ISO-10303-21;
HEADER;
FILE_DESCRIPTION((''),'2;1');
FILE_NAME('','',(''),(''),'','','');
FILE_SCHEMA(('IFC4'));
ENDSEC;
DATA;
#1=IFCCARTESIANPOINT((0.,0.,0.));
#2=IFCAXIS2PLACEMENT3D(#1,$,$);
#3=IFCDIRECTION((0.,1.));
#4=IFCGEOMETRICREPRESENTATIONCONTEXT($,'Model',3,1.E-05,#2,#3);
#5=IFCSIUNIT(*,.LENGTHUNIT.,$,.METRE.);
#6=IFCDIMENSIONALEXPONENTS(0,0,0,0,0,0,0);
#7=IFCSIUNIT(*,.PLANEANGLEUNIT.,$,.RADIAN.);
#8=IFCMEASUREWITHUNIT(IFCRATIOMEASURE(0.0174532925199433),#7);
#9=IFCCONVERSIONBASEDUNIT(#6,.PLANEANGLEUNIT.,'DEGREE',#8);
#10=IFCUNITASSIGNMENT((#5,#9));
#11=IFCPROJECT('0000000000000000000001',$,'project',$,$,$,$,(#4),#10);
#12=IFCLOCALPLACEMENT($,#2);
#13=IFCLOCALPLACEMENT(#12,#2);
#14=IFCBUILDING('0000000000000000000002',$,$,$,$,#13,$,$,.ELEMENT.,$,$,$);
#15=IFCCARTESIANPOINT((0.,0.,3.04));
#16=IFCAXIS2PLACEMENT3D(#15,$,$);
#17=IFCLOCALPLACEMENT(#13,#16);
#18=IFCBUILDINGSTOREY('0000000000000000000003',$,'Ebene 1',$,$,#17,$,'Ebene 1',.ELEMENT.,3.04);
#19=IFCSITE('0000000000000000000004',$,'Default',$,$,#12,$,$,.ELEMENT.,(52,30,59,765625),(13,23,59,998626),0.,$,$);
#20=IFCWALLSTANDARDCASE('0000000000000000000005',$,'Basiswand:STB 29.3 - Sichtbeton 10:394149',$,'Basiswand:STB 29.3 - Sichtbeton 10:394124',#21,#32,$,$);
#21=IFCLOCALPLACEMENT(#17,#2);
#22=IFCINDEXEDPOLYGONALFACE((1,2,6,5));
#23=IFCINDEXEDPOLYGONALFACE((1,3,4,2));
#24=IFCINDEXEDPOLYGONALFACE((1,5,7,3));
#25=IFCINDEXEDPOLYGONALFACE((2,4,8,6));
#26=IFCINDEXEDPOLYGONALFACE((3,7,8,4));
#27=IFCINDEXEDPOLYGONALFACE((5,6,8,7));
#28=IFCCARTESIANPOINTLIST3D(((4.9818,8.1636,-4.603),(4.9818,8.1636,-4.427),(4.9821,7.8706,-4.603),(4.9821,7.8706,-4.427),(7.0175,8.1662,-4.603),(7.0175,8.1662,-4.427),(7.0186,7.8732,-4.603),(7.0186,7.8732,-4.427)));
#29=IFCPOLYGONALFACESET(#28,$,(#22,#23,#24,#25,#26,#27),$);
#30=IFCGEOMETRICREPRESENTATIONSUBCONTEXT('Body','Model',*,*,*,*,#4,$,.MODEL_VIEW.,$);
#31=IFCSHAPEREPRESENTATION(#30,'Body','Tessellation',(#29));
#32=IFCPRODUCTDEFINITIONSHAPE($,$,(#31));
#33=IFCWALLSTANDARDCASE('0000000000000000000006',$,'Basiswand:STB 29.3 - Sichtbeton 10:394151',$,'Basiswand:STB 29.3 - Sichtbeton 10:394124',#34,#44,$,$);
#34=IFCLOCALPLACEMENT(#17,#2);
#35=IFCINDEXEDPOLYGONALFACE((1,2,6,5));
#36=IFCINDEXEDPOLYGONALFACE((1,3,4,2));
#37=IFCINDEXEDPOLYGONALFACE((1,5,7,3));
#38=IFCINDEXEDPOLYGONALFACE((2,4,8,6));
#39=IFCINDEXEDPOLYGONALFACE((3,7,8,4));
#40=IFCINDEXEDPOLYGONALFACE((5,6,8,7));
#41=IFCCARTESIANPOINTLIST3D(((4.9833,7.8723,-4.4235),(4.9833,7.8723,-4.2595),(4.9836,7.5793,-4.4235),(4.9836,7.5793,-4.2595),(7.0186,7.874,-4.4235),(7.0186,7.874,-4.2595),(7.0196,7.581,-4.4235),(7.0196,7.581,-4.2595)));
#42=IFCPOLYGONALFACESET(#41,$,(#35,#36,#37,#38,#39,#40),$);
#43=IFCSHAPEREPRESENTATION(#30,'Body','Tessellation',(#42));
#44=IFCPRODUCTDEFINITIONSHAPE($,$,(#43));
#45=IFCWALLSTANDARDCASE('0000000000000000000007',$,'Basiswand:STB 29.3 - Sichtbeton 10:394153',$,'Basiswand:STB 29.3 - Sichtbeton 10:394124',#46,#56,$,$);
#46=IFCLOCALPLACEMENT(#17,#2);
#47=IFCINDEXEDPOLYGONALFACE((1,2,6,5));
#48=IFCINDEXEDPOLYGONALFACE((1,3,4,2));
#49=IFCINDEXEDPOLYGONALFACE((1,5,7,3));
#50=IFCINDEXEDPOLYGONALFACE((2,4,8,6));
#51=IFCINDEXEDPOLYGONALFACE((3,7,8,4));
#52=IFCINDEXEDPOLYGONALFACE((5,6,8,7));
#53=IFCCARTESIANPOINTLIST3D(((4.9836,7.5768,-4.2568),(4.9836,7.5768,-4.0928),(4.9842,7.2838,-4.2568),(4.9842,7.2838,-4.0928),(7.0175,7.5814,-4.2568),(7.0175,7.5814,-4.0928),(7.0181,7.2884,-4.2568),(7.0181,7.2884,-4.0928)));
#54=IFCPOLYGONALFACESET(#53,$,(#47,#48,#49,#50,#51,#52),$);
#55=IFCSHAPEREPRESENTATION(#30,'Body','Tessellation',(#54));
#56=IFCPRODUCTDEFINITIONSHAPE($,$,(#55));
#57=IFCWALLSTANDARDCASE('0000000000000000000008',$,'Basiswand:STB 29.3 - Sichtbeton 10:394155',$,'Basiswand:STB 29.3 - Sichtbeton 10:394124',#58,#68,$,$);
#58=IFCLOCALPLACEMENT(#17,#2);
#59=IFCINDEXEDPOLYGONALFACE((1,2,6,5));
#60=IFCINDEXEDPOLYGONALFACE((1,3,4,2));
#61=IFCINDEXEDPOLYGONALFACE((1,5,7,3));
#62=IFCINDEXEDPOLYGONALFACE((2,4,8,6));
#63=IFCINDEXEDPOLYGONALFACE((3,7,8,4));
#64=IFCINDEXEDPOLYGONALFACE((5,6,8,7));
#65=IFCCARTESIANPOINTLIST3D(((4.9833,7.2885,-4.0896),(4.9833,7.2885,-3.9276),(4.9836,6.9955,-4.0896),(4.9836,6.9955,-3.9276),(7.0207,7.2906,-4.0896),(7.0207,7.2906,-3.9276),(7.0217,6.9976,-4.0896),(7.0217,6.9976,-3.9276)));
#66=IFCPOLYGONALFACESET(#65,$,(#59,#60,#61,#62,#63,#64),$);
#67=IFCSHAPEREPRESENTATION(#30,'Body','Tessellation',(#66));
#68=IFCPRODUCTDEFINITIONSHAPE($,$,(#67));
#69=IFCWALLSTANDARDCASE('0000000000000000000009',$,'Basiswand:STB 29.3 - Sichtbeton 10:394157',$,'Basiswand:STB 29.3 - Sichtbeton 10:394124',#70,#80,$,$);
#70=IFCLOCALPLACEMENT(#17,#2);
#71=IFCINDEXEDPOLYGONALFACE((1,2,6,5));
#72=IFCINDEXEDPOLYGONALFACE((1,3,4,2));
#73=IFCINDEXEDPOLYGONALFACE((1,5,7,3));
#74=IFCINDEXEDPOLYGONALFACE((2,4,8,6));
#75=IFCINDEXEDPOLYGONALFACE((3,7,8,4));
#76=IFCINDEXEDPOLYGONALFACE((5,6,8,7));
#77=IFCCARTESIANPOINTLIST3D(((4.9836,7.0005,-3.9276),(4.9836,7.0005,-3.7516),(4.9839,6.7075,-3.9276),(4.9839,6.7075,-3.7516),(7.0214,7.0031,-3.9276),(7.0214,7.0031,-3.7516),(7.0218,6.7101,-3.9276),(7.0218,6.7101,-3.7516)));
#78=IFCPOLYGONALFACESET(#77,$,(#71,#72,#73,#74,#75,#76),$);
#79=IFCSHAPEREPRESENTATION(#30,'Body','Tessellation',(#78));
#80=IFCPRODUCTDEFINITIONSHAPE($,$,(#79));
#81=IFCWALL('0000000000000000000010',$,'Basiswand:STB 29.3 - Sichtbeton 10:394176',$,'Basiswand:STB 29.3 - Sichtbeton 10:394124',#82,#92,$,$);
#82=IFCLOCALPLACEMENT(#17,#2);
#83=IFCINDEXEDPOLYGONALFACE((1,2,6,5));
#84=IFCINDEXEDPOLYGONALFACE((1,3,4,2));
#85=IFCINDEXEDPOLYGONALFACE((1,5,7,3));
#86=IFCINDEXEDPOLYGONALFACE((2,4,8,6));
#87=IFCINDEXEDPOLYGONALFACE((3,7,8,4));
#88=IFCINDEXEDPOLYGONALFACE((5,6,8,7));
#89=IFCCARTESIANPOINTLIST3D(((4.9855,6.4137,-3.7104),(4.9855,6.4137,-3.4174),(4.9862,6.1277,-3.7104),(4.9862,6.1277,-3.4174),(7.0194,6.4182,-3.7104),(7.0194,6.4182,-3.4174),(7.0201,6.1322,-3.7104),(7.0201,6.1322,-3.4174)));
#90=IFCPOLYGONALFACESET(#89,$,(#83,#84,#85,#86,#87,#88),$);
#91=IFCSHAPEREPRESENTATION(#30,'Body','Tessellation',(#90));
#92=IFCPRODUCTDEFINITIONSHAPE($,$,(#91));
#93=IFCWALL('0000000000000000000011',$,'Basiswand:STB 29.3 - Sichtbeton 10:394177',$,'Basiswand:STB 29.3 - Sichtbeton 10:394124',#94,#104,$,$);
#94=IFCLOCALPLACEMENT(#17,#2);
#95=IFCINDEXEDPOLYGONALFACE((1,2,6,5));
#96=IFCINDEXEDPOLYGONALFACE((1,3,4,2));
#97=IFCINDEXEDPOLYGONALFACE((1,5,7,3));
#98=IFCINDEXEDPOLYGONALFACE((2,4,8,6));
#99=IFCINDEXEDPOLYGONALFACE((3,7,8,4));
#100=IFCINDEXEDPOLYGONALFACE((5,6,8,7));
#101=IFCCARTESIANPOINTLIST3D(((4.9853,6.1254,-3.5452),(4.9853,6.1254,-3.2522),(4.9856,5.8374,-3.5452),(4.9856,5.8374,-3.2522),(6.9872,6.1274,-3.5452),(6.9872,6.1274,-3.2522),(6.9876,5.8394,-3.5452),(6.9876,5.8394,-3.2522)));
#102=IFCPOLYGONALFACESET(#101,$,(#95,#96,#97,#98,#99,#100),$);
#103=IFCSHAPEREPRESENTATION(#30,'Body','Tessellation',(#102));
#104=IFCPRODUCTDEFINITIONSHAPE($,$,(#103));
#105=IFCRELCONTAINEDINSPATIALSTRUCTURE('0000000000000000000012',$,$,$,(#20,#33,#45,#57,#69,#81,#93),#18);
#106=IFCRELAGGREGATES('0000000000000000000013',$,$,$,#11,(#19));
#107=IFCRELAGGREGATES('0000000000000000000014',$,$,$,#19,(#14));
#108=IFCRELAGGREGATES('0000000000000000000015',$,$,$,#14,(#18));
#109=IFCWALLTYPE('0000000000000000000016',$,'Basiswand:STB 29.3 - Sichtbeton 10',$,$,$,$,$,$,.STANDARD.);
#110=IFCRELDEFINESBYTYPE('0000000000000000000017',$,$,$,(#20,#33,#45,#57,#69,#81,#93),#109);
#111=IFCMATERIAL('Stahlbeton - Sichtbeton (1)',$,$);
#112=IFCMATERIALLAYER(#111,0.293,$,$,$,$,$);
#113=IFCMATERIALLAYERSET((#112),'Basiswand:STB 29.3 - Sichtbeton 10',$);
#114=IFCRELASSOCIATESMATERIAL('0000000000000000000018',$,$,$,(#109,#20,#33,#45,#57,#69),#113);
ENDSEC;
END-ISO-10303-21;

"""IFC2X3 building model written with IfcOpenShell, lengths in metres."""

from ifc_helpers import new_model, entity, si_unit, converted_unit, direction, frame, frame_2d, origin, place, context, subcontext, project, spatial, polyline, rectangle, outline, extrude, clip, halfspace, material, layer, layer_set, layer_usage, type_object, element, save


model = new_model("IFC2X3")

# Units and contexts
model_context = context("Model", 3, precision=1e-05, world=origin(), true_north=direction((0.0, 1.0)))
body_context = subcontext(model_context, "Body", "Model", "MODEL_VIEW")
ifc_project = project(units=[si_unit("LENGTHUNIT", "METRE"), converted_unit("PLANEANGLEUNIT", "DEGREE", entity("IfcRatioMeasure", 0.0174532925199433), si_unit("PLANEANGLEUNIT", "RADIAN"), dimensions=[0, 0, 0, 0, 0, 0, 0])], contexts=[model_context])

# Site, building, storey
site_placement = place(None, origin())
site = spatial("IfcSite", under=ifc_project, at=site_placement, Name="Default", CompositionType="ELEMENT", RefLatitude=(52, 30, 59, 765625), RefLongitude=(13, 23, 59, 998626), RefElevation=0.0)
building_placement = place(site_placement, origin())
building = spatial("IfcBuilding", under=site, at=building_placement, CompositionType="ELEMENT")
storey_placement = place(building_placement, frame((0.0, 0.0, 3.04)))
storey = spatial("IfcBuildingStorey", under=building, at=storey_placement, Name="Ebene 1", LongName="Ebene 1", CompositionType="ELEMENT", Elevation=3.04)

# Walls
ifc_material = material(Name="Stahlbeton - Sichtbeton (1)")
ifc_layer = layer(ifc_material, 0.293)
ifc_layer_set = layer_set([ifc_layer], Name="Basiswand:STB 29.3 - Sichtbeton 10")
ifc_layer_usage_1 = layer_usage(ifc_layer_set, "AXIS2", "POSITIVE", -0.1465)
wall_type = type_object("IfcWallType", Name="Basiswand:STB 29.3 - Sichtbeton 10", PredefinedType="STANDARD", material=ifc_layer_set)
wall_1_placement = place(storey_placement, frame((7.0184, 8.0197, -4.603), z_axis=(0.0, 0.0, 1.0), x_axis=(-0.999999, -0.001264, 0.0)))
element("IfcWallStandardCase", 1, at=wall_1_placement, inside=storey, type_object=wall_type, material=ifc_layer_usage_1, Name="Basiswand:STB 29.3 - Sichtbeton 10:394149", ObjectType="Basiswand:STB 29.3 - Sichtbeton 10:394124", context=body_context, shape_type="SweptSolid", body=[
    extrude(outline(polyline([(2.0364, -0.1465), (2.0364, 0.1465), (0.0, 0.1465), (0.0007, -0.1465), (2.0364, -0.1465)])), origin(), (0.0, 0.0, 1.0), 0.176),
])
ifc_layer_usage_2 = layer_usage(ifc_layer_set, "AXIS2", "POSITIVE", -0.1465)
wall_2_placement = place(storey_placement, frame((7.0195, 7.7275, -4.4235), z_axis=(0.0, 0.0, 1.0), x_axis=(-1.0, -0.000827, 0.0)))
element("IfcWallStandardCase", 2, at=wall_2_placement, inside=storey, type_object=wall_type, material=ifc_layer_usage_2, Name="Basiswand:STB 29.3 - Sichtbeton 10:394151", ObjectType="Basiswand:STB 29.3 - Sichtbeton 10:394124", context=body_context, shape_type="SweptSolid", body=[
    extrude(outline(polyline([(2.0361, -0.1465), (2.0361, 0.1465), (0.0, 0.1465), (0.0008, -0.1465), (2.0361, -0.1465)])), origin(), (0.0, 0.0, 1.0), 0.164),
])
ifc_layer_usage_3 = layer_usage(ifc_layer_set, "AXIS2", "POSITIVE", -0.1465)
wall_3_placement = place(storey_placement, frame((7.0178, 7.4349, -4.2568), z_axis=(0.0, 0.0, 1.0), x_axis=(-0.999998, -0.002231, 0.0)))
element("IfcWallStandardCase", 3, at=wall_3_placement, inside=storey, type_object=wall_type, material=ifc_layer_usage_3, Name="Basiswand:STB 29.3 - Sichtbeton 10:394153", ObjectType="Basiswand:STB 29.3 - Sichtbeton 10:394124", context=body_context, shape_type="SweptSolid", body=[
    extrude(rectangle(XDim=2.0339, YDim=0.293, at=frame_2d((1.0169, 0.0), x_axis=(-1.0, 0.0))), origin(), (0.0, 0.0, 1.0), 0.164),
])
ifc_layer_usage_4 = layer_usage(ifc_layer_set, "AXIS2", "POSITIVE", -0.1465)
wall_4_placement = place(storey_placement, frame((7.0216, 7.1441, -4.0896), z_axis=(0.0, 0.0, 1.0), x_axis=(-0.999999, -0.001024, 0.0)))
element("IfcWallStandardCase", 4, at=wall_4_placement, inside=storey, type_object=wall_type, material=ifc_layer_usage_4, Name="Basiswand:STB 29.3 - Sichtbeton 10:394155", ObjectType="Basiswand:STB 29.3 - Sichtbeton 10:394124", context=body_context, shape_type="SweptSolid", body=[
    extrude(outline(polyline([(2.0382, -0.1465), (2.0382, 0.1465), (0.0, 0.1465), (0.0008, -0.1465), (2.0382, -0.1465)])), origin(), (0.0, 0.0, 1.0), 0.162),
])
ifc_layer_usage_5 = layer_usage(ifc_layer_set, "AXIS2", "POSITIVE", -0.1465)
wall_5_placement = place(storey_placement, frame((7.0216, 6.8566, -4.0016), z_axis=(0.0, 0.0, 1.0), x_axis=(-0.999999, -0.001264, 0.0)))
element("IfcWallStandardCase", 5, at=wall_5_placement, inside=storey, type_object=wall_type, material=ifc_layer_usage_5, Name="Basiswand:STB 29.3 - Sichtbeton 10:394157", ObjectType="Basiswand:STB 29.3 - Sichtbeton 10:394124", context=body_context, shape_type="Clipping", body=[
    clip(extrude(rectangle(XDim=2.0379, YDim=0.293, at=frame_2d((1.0189, 0.0), x_axis=(-1.0, 0.0))), origin(), (0.0, 0.0, 1.0), 0.25), halfspace(frame((2.0379, -0.1465, 0.074), z_axis=(0.0, 0.0, -1.0), x_axis=(0.0, 1.0, 0.0)), False)),
])
wall_6_placement = place(storey_placement, frame((4.9855, 6.1277, -3.7104)))
element("IfcWall", 6, at=wall_6_placement, inside=storey, type_object=wall_type, Name="Basiswand:STB 29.3 - Sichtbeton 10:394176", ObjectType="Basiswand:STB 29.3 - Sichtbeton 10:394124", context=body_context, shape_type="SweptSolid", body=[
    extrude(outline(polyline([(-1.0169, -0.143), (1.017, -0.143), (1.0169, 0.143), (-1.017, 0.143), (-1.0169, -0.143)])), frame((1.0173, 0.1453, 0.0), z_axis=(0.0, 0.0, 1.0), x_axis=(0.999998, 0.002231, 0.0)), (0.0, 0.0, 1.0), 0.293),
])
wall_7_placement = place(storey_placement, frame((4.9853, 5.8374, -3.5452)))
element("IfcWall", 7, at=wall_7_placement, inside=storey, type_object=wall_type, Name="Basiswand:STB 29.3 - Sichtbeton 10:394177", ObjectType="Basiswand:STB 29.3 - Sichtbeton 10:394124", context=body_context, shape_type="SweptSolid", body=[
    extrude(outline(polyline([(-1.0009, -0.144), (1.001, -0.144), (1.0009, 0.144), (-1.001, 0.144), (-1.0009, -0.144)])), frame((1.0011, 0.145, 0.0), z_axis=(0.0, 0.0, 1.0), x_axis=(0.999999, 0.001024, 0.0)), (0.0, 0.0, 1.0), 0.293),
])

save(model, "model.ifc")
